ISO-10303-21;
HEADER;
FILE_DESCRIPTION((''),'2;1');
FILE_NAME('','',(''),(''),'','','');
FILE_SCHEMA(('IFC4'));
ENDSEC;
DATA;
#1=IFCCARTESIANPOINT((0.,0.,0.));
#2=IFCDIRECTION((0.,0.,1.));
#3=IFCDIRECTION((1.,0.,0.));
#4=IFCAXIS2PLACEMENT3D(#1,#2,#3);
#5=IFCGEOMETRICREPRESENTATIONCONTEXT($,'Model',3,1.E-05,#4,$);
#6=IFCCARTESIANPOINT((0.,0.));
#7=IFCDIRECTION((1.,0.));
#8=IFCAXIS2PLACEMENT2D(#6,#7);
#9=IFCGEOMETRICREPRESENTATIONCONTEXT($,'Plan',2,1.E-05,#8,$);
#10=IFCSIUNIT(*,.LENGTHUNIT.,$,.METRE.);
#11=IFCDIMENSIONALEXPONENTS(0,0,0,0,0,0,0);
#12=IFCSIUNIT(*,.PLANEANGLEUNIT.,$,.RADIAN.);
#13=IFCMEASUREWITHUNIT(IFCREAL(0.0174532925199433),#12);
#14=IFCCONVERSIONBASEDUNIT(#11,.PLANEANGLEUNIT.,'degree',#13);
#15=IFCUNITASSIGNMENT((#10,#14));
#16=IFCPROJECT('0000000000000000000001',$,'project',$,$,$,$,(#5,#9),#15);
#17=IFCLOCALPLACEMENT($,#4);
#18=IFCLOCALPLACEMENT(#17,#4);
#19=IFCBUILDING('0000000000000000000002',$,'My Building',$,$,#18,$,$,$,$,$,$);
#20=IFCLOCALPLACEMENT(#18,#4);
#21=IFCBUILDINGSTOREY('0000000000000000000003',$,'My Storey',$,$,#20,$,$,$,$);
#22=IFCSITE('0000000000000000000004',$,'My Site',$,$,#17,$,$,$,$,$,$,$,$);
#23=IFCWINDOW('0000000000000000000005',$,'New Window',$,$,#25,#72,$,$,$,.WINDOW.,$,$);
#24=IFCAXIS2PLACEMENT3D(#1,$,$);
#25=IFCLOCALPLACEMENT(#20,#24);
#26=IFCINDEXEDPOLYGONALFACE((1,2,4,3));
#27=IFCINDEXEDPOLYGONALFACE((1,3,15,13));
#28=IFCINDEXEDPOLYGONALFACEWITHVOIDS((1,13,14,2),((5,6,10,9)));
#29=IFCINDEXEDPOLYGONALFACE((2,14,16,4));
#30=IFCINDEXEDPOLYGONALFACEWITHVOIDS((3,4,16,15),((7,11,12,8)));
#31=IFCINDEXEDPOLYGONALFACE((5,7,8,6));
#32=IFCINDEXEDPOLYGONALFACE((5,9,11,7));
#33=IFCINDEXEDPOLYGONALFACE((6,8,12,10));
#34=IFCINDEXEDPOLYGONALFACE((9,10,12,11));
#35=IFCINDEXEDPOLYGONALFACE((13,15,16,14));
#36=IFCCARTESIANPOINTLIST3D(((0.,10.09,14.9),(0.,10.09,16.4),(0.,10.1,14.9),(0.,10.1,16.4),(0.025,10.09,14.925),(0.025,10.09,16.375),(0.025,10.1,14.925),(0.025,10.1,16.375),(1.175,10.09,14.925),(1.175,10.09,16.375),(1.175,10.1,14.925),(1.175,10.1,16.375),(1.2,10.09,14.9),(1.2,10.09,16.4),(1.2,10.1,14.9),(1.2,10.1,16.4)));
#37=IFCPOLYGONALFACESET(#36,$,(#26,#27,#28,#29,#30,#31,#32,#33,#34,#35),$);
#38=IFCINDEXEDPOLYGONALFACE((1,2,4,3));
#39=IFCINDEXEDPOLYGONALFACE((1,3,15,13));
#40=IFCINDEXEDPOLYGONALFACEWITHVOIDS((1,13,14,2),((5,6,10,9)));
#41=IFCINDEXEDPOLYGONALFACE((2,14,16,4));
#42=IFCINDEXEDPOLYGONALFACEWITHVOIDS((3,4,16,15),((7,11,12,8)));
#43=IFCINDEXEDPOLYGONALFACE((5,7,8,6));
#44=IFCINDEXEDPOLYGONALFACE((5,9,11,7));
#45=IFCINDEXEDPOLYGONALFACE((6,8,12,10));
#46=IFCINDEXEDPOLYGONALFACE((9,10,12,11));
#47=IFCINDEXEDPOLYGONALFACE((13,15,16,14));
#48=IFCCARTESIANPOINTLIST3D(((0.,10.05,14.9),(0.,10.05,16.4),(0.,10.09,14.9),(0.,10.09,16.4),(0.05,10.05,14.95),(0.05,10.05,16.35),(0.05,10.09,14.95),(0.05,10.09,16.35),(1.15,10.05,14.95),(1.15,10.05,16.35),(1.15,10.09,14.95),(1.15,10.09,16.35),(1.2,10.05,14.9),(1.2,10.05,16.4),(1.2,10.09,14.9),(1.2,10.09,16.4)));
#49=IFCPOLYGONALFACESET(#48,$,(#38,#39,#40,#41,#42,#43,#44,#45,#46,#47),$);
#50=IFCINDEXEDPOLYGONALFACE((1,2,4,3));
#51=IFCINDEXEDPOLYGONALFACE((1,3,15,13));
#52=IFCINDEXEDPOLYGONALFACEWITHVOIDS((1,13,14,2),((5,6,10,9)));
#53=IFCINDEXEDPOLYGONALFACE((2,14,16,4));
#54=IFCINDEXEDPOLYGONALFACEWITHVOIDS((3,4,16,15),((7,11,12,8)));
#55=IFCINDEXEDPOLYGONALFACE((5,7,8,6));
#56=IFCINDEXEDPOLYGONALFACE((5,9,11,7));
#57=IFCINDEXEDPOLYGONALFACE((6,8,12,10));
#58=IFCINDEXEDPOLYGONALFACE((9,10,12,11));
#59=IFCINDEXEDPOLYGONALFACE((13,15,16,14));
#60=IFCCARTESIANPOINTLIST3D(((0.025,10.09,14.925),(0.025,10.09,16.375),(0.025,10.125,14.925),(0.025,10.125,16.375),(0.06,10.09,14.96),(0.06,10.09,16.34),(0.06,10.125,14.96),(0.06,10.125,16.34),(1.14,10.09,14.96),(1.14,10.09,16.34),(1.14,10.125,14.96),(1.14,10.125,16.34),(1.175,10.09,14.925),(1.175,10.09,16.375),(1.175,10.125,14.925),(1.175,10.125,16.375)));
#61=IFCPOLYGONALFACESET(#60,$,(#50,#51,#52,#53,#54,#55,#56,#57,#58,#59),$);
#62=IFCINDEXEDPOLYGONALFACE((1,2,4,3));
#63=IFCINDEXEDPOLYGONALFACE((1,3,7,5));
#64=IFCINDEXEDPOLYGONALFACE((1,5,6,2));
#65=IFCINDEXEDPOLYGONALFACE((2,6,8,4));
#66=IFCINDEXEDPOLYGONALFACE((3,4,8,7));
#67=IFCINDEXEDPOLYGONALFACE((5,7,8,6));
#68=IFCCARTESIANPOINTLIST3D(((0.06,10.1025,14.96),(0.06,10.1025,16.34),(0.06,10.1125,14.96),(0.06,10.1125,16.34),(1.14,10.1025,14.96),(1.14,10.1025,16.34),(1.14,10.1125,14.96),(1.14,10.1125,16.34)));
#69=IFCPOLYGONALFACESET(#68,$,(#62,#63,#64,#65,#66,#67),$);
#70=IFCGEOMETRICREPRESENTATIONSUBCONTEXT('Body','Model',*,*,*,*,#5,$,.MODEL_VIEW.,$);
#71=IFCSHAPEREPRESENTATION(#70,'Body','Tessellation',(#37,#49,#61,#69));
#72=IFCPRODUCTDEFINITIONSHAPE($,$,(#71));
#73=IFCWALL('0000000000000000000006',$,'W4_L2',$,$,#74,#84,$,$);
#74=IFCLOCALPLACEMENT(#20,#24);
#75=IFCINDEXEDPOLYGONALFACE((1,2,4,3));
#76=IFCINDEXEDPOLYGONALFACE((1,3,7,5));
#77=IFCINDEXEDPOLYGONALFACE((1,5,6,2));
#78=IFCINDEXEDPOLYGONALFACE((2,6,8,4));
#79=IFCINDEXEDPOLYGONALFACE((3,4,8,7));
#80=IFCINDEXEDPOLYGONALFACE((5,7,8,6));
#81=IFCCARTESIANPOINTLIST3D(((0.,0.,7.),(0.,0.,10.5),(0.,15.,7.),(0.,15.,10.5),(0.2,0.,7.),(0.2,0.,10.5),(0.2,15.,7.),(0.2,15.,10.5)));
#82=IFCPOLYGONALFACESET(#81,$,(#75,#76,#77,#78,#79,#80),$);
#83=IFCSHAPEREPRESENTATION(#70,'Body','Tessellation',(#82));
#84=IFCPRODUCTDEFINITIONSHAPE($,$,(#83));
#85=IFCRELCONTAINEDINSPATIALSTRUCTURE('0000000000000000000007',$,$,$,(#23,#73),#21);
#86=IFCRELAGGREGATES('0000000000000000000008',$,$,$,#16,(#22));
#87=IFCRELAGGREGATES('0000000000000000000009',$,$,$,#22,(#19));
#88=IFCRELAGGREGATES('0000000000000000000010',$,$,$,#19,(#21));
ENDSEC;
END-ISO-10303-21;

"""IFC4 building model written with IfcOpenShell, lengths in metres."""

from ifc_helpers import new_model, entity, si_unit, converted_unit, frame, origin_with_axes, origin_2d_with_axis, place, context, subcontext, project, spatial, line, indexed_curve, outline, extrude, element, save


model = new_model("IFC4")

# Units and contexts
model_context = context("Model", 3, precision=1e-05, world=origin_with_axes())
plan_context = context("Plan", 2, precision=1e-05, world=origin_2d_with_axis())
body_context = subcontext(model_context, "Body", "Model", "MODEL_VIEW")
ifc_project = project(units=[si_unit("LENGTHUNIT", "METRE"), converted_unit("PLANEANGLEUNIT", "degree", entity("IfcReal", 0.0174532925199433), si_unit("PLANEANGLEUNIT", "RADIAN"), dimensions=[0, 0, 0, 0, 0, 0, 0])], contexts=[model_context, plan_context])

# Site, building, storey
site_placement = place(None, origin_with_axes())
site = spatial("IfcSite", under=ifc_project, at=site_placement, Name="My Site")
building_placement = place(site_placement, origin_with_axes())
building = spatial("IfcBuilding", under=site, at=building_placement, Name="My Building")
storey_placement = place(building_placement, origin_with_axes())
storey = spatial("IfcBuildingStorey", under=building, at=storey_placement, Name="My Storey")

# Window
window_placement = place(storey_placement, frame((0.0, 10.0, 14.9), z_axis=(0.0, 0.0, 1.0), x_axis=(1.0, 0.0, 0.0)))
element("IfcWindow", 1, at=window_placement, inside=storey, Name="New Window", PredefinedType="WINDOW", context=body_context, shape_type="SweptSolid", body=[
    extrude(outline(indexed_curve([(0.0, 0.0), (1.2, 0.0), (1.2, 1.5), (0.0, 1.5)], segments=[line(1, 2, 3, 4, 1)]), holes=[indexed_curve([(0.025, 0.025), (1.175, 0.025), (1.175, 1.475), (0.025, 1.475)], segments=[line(1, 2, 3, 4, 1)])]), frame((0.0, 0.09, 0.0), z_axis=(0.0, -1.0, 0.0), x_axis=(1.0, 0.0, 0.0)), (0.0, 0.0, -1.0), 0.01),
    extrude(outline(indexed_curve([(0.0, 0.0), (1.2, 0.0), (1.2, 1.5), (0.0, 1.5)], segments=[line(1, 2, 3, 4, 1)]), holes=[indexed_curve([(0.05, 0.05), (1.15, 0.05), (1.15, 1.45), (0.05, 1.45)], segments=[line(1, 2, 3, 4, 1)])]), frame((0.0, 0.05, 0.0), z_axis=(0.0, -1.0, 0.0), x_axis=(1.0, 0.0, 0.0)), (0.0, 0.0, -1.0), 0.04),
    extrude(outline(indexed_curve([(0.0, 0.0), (1.15, 0.0), (1.15, 1.45), (0.0, 1.45)], segments=[line(1, 2, 3, 4, 1)]), holes=[indexed_curve([(0.035, 0.035), (1.115, 0.035), (1.115, 1.415), (0.035, 1.415)], segments=[line(1, 2, 3, 4, 1)])]), frame((0.025, 0.09, 0.025), z_axis=(0.0, -1.0, 0.0), x_axis=(1.0, 0.0, 0.0)), (0.0, 0.0, -1.0), 0.035),
    extrude(outline(indexed_curve([(0.035, 0.035), (1.115, 0.035), (1.115, 1.415), (0.035, 1.415)], segments=[line(1, 2, 3, 4, 1)])), frame((0.025, 0.1025, 0.025), z_axis=(0.0, -1.0, 0.0), x_axis=(1.0, 0.0, 0.0)), (0.0, 0.0, -1.0), 0.01),
])

# Wall
for number, where, z_axis, x_axis, name in (
    (2, (0.0, 15.0, 7.0), (0.0, 0.0, 1.0), (0.0, -1.0, 0.0), "W4_L2"),
):
    element("IfcWall", number, at=place(storey_placement, frame(where, z_axis=z_axis, x_axis=x_axis)), inside=storey, Name=name, context=body_context, shape_type="SweptSolid", body=[
        extrude(outline(indexed_curve([(0.0, 0.0), (0.0, 0.2), (15.0, 0.2), (15.0, 0.0), (0.0, 0.0)], self_intersect=False)), origin_with_axes(), (0.0, 0.0, 1.0), 3.5),
    ])

save(model, "model.ifc")
